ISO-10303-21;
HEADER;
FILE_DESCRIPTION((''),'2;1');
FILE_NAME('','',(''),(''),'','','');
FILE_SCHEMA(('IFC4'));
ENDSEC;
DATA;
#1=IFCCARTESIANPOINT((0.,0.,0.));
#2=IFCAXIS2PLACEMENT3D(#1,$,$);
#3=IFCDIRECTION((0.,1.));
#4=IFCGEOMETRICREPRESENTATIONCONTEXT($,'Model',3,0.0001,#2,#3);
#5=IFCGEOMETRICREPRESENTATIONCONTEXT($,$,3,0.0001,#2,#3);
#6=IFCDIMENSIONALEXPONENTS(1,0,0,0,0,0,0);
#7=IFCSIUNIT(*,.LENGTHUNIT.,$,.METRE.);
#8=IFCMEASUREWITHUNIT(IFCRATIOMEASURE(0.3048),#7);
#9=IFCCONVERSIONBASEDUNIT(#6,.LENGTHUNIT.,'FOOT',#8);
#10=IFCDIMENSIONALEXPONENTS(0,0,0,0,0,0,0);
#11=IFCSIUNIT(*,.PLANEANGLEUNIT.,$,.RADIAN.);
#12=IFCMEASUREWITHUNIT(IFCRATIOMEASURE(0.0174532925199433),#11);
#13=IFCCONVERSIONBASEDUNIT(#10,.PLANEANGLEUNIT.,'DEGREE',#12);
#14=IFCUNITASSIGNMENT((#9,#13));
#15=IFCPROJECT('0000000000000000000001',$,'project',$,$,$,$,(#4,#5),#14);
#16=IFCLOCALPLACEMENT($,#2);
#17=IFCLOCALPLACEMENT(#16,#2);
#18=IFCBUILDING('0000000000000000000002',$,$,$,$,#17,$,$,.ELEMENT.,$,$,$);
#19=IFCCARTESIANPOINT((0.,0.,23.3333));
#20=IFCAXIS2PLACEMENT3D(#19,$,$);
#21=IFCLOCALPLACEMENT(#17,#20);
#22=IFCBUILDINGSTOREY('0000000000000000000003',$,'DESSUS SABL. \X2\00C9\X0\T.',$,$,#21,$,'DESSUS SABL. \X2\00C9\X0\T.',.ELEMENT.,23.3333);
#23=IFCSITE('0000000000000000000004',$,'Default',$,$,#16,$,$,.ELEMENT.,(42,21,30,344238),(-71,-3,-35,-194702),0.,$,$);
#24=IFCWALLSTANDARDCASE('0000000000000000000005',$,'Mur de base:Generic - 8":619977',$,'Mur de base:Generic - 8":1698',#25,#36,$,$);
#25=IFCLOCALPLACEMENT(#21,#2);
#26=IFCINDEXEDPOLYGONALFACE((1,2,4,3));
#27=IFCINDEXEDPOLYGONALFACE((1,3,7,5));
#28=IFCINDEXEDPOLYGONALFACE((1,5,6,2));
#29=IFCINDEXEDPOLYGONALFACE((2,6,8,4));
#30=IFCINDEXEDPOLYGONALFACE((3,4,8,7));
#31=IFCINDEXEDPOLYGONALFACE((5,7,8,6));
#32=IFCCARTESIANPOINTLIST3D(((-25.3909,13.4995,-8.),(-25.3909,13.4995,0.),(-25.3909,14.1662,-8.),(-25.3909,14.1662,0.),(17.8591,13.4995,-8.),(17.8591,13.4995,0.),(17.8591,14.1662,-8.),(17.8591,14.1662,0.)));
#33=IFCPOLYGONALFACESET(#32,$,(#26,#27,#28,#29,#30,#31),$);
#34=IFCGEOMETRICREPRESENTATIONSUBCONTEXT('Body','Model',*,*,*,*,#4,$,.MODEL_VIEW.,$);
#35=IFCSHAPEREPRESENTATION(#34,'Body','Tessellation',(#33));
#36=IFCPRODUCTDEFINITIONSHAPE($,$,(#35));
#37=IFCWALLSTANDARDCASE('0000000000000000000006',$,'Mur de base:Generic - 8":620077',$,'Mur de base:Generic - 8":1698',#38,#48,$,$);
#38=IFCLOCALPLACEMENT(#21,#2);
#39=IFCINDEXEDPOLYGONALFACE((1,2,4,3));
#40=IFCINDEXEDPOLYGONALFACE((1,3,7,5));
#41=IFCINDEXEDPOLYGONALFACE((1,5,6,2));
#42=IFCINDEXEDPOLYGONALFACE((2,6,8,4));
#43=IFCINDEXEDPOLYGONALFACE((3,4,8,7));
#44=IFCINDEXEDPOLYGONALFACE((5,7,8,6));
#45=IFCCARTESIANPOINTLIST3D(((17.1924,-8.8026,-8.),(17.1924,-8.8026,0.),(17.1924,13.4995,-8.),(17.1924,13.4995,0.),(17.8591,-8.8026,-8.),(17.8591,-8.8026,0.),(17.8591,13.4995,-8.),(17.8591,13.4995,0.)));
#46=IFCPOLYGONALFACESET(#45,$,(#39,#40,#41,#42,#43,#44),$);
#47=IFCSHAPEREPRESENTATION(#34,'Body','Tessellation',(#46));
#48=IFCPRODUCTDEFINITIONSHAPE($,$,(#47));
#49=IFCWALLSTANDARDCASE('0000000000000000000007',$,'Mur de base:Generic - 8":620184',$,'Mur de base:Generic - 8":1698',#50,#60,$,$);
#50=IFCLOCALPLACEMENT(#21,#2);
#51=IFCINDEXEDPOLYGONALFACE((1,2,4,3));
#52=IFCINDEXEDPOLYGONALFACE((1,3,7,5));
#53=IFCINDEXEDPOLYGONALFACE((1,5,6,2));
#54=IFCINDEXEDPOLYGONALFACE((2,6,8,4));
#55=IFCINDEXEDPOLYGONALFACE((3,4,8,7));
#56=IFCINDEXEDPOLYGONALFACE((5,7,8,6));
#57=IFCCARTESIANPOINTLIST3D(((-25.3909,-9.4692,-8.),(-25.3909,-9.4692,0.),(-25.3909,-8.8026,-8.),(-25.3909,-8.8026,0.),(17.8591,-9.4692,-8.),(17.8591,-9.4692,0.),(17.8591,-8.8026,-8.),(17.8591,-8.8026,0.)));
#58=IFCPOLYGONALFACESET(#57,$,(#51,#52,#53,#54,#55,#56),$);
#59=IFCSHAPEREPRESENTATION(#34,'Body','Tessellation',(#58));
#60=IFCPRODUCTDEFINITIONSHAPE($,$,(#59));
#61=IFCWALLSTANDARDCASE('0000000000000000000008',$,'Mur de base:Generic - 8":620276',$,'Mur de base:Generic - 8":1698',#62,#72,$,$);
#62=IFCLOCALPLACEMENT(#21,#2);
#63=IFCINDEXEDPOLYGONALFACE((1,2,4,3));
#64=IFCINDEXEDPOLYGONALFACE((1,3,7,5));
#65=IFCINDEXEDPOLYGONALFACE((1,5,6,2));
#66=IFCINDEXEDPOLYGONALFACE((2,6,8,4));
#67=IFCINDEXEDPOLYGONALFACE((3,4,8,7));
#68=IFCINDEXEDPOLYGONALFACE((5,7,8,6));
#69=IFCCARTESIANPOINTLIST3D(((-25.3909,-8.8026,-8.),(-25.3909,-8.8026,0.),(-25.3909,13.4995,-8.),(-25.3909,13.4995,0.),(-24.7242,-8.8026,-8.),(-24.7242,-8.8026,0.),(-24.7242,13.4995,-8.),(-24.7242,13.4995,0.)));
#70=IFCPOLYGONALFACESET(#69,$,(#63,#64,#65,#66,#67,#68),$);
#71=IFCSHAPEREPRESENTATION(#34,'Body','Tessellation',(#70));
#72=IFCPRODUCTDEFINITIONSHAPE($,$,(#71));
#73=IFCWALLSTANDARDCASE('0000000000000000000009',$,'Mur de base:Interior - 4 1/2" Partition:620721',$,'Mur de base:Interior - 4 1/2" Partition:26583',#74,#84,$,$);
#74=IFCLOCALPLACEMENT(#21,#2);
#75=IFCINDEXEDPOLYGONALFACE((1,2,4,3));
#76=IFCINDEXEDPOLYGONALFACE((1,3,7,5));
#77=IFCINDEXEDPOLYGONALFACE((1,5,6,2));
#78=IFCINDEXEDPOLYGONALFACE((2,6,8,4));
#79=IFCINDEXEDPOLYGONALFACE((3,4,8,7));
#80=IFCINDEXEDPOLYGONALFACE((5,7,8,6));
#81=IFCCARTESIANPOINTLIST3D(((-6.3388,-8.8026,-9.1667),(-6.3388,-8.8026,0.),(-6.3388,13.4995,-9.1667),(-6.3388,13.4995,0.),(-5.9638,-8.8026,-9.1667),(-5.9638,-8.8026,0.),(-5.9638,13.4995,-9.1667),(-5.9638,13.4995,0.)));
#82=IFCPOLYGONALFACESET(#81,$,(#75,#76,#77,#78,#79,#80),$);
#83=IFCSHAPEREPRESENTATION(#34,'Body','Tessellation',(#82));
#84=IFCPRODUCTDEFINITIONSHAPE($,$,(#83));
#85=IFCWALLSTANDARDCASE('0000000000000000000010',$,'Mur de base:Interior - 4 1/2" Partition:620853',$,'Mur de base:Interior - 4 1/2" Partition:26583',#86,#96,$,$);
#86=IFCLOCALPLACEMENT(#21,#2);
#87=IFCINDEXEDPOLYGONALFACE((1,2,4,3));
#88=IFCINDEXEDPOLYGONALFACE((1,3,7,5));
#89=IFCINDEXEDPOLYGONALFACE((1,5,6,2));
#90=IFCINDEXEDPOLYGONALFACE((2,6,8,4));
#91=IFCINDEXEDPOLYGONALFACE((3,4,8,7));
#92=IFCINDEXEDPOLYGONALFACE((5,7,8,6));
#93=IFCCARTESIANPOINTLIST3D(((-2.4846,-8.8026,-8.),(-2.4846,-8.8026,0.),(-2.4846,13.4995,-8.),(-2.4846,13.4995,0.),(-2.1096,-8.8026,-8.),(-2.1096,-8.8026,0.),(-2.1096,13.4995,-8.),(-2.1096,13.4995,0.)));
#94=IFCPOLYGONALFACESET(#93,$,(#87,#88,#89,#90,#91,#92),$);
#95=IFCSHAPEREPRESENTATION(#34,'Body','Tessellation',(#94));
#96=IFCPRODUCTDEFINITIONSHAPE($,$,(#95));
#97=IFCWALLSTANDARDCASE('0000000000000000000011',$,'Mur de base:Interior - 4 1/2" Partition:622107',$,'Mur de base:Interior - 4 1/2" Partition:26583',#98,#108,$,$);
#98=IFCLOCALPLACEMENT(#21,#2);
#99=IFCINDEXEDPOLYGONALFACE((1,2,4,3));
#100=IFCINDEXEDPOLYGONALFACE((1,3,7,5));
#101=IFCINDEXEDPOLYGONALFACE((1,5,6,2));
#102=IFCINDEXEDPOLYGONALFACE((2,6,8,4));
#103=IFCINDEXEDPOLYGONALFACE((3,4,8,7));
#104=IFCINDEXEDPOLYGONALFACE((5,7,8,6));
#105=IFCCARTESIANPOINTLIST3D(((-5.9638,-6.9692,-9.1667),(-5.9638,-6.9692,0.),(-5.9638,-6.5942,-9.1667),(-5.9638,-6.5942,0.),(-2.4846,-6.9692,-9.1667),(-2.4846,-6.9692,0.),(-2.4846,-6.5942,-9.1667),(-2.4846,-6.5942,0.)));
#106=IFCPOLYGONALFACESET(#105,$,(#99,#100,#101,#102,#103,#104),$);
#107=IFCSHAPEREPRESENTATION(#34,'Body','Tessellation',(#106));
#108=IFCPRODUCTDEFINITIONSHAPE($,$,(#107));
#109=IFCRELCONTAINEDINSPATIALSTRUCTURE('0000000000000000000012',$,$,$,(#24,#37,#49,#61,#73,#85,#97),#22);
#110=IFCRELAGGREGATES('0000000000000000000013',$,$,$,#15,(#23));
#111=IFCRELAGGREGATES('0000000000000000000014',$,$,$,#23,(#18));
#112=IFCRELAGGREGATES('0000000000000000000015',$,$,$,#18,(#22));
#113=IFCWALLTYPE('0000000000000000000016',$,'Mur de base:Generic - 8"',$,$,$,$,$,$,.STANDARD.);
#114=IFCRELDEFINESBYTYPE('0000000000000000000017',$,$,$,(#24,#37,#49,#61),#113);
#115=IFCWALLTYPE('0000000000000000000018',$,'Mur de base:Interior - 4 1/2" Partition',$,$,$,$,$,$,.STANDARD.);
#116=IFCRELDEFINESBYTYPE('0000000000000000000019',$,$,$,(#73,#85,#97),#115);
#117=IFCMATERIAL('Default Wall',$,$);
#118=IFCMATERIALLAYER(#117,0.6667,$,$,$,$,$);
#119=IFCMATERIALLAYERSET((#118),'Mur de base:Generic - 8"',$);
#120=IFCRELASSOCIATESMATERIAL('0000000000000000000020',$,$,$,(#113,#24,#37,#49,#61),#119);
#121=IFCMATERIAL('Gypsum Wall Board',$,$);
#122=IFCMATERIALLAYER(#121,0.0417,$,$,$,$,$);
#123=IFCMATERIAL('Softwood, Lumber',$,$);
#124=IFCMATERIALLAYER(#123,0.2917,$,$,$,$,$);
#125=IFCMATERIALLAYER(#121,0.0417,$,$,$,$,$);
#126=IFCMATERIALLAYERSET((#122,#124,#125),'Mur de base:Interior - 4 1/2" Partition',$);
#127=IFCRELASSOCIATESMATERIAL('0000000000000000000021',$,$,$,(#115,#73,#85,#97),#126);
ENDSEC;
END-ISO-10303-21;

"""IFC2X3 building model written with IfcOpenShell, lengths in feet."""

from ifc_helpers import new_model, entity, si_unit, converted_unit, direction, frame, frame_2d, origin, place, context, subcontext, project, spatial, rectangle, extrude, material, layer, layer_set, layer_usage, type_object, element, save


model = new_model("IFC2X3")

# Units and contexts
model_context = context("Model", 3, precision=0.0001, world=origin(), true_north=direction((0.0, 1.0)))
context_of_model = context(None, 3, precision=0.0001, world=origin(), true_north=direction((0.0, 1.0)))
body_context = subcontext(model_context, "Body", "Model", "MODEL_VIEW")
ifc_project = project(units=[converted_unit("LENGTHUNIT", "FOOT", entity("IfcRatioMeasure", 0.3048), si_unit("LENGTHUNIT", "METRE"), dimensions=[1, 0, 0, 0, 0, 0, 0]), converted_unit("PLANEANGLEUNIT", "DEGREE", entity("IfcRatioMeasure", 0.0174532925199433), si_unit("PLANEANGLEUNIT", "RADIAN"), dimensions=[0, 0, 0, 0, 0, 0, 0])], contexts=[model_context, context_of_model])

# Site, building, storey
site_placement = place(None, origin())
site = spatial("IfcSite", under=ifc_project, at=site_placement, Name="Default", CompositionType="ELEMENT", RefLatitude=(42, 21, 30, 344238), RefLongitude=(-71, -3, -35, -194702), RefElevation=0.0)
building_placement = place(site_placement, origin())
building = spatial("IfcBuilding", under=site, at=building_placement, CompositionType="ELEMENT")
storey_placement = place(building_placement, frame((0.0, 0.0, 23.3333)))
storey = spatial("IfcBuildingStorey", under=building, at=storey_placement, Name="DESSUS SABL. ÉT.", LongName="DESSUS SABL. ÉT.", CompositionType="ELEMENT", Elevation=23.3333)

# Walls
ifc_material_1 = material(Name="Default Wall")
ifc_layer_1 = layer(ifc_material_1, 0.6667)
ifc_layer_set_1 = layer_set([ifc_layer_1], Name="Mur de base:Generic - 8\"")
ifc_layer_usage_1 = layer_usage(ifc_layer_set_1, "AXIS2", "NEGATIVE", 0.3333)
wall_type_1 = type_object("IfcWallType", Name="Mur de base:Generic - 8\"", PredefinedType="STANDARD", material=ifc_layer_set_1)
wall_1_placement = place(storey_placement, frame((-25.3909, 13.8328, -8.0)))
element("IfcWallStandardCase", 1, at=wall_1_placement, inside=storey, type_object=wall_type_1, material=ifc_layer_usage_1, Name="Mur de base:Generic - 8\":619977", ObjectType="Mur de base:Generic - 8\":1698", context=body_context, shape_type="SweptSolid", body=[
    extrude(rectangle(XDim=43.25, YDim=0.6667, at=frame_2d((21.625, 0.0), x_axis=(-1.0, 0.0))), origin(), (0.0, 0.0, 1.0), 8.0),
])
ifc_layer_usage_2 = layer_usage(ifc_layer_set_1, "AXIS2", "NEGATIVE", 0.3333)
wall_2_placement = place(storey_placement, frame((17.5258, 13.4995, -8.0), z_axis=(0.0, 0.0, 1.0), x_axis=(0.0, -1.0, 0.0)))
element("IfcWallStandardCase", 2, at=wall_2_placement, inside=storey, type_object=wall_type_1, material=ifc_layer_usage_2, Name="Mur de base:Generic - 8\":620077", ObjectType="Mur de base:Generic - 8\":1698", context=body_context, shape_type="SweptSolid", body=[
    extrude(rectangle(XDim=22.3021, YDim=0.6667, at=frame_2d((11.151, 0.0), x_axis=(-1.0, 0.0))), origin(), (0.0, 0.0, 1.0), 8.0),
])
ifc_layer_usage_3 = layer_usage(ifc_layer_set_1, "AXIS2", "NEGATIVE", 0.3333)
wall_3_placement = place(storey_placement, frame((17.8591, -9.1359, -8.0), z_axis=(0.0, 0.0, 1.0), x_axis=(-1.0, 0.0, 0.0)))
element("IfcWallStandardCase", 3, at=wall_3_placement, inside=storey, type_object=wall_type_1, material=ifc_layer_usage_3, Name="Mur de base:Generic - 8\":620184", ObjectType="Mur de base:Generic - 8\":1698", context=body_context, shape_type="SweptSolid", body=[
    extrude(rectangle(XDim=43.25, YDim=0.6667, at=frame_2d((21.625, 0.0), x_axis=(-1.0, 0.0))), origin(), (0.0, 0.0, 1.0), 8.0),
])
ifc_layer_usage_4 = layer_usage(ifc_layer_set_1, "AXIS2", "NEGATIVE", 0.3333)
wall_4_placement = place(storey_placement, frame((-25.0576, -8.8026, -8.0), z_axis=(0.0, 0.0, 1.0), x_axis=(0.0, 1.0, 0.0)))
element("IfcWallStandardCase", 4, at=wall_4_placement, inside=storey, type_object=wall_type_1, material=ifc_layer_usage_4, Name="Mur de base:Generic - 8\":620276", ObjectType="Mur de base:Generic - 8\":1698", context=body_context, shape_type="SweptSolid", body=[
    extrude(rectangle(XDim=22.3021, YDim=0.6667, at=frame_2d((11.151, 0.0), x_axis=(-1.0, 0.0))), origin(), (0.0, 0.0, 1.0), 8.0),
])
ifc_material_2 = material(Name="Gypsum Wall Board")
ifc_layer_2 = layer(ifc_material_2, 0.0417)
ifc_material_3 = material(Name="Softwood, Lumber")
ifc_layer_3 = layer(ifc_material_3, 0.2917)
ifc_layer_4 = layer(ifc_material_2, 0.0417)
ifc_layer_set_2 = layer_set([ifc_layer_2, ifc_layer_3, ifc_layer_4], Name="Mur de base:Interior - 4 1/2\" Partition")
ifc_layer_usage_5 = layer_usage(ifc_layer_set_2, "AXIS2", "NEGATIVE", 0.1875)
wall_type_2 = type_object("IfcWallType", Name="Mur de base:Interior - 4 1/2\" Partition", PredefinedType="STANDARD", material=ifc_layer_set_2)
wall_5_placement = place(storey_placement, frame((-6.1513, 13.4995, -9.1667), z_axis=(0.0, 0.0, 1.0), x_axis=(0.0, -1.0, 0.0)))
element("IfcWallStandardCase", 5, at=wall_5_placement, inside=storey, type_object=wall_type_2, material=ifc_layer_usage_5, Name="Mur de base:Interior - 4 1/2\" Partition:620721", ObjectType="Mur de base:Interior - 4 1/2\" Partition:26583", context=body_context, shape_type="SweptSolid", body=[
    extrude(rectangle(XDim=22.3021, YDim=0.375, at=frame_2d((11.151, 0.0), x_axis=(-1.0, 0.0))), origin(), (0.0, 0.0, 1.0), 9.1667),
])
ifc_layer_usage_6 = layer_usage(ifc_layer_set_2, "AXIS2", "NEGATIVE", 0.1875)
wall_6_placement = place(storey_placement, frame((-2.2971, 13.4995, -8.0), z_axis=(0.0, 0.0, 1.0), x_axis=(0.0, -1.0, 0.0)))
element("IfcWallStandardCase", 6, at=wall_6_placement, inside=storey, type_object=wall_type_2, material=ifc_layer_usage_6, Name="Mur de base:Interior - 4 1/2\" Partition:620853", ObjectType="Mur de base:Interior - 4 1/2\" Partition:26583", context=body_context, shape_type="SweptSolid", body=[
    extrude(rectangle(XDim=22.3021, YDim=0.375, at=frame_2d((11.151, 0.0), x_axis=(-1.0, 0.0))), origin(), (0.0, 0.0, 1.0), 8.0),
])
ifc_layer_usage_7 = layer_usage(ifc_layer_set_2, "AXIS2", "NEGATIVE", 0.1875)
wall_7_placement = place(storey_placement, frame((-5.9638, -6.7817, -9.1667)))
element("IfcWallStandardCase", 7, at=wall_7_placement, inside=storey, type_object=wall_type_2, material=ifc_layer_usage_7, Name="Mur de base:Interior - 4 1/2\" Partition:622107", ObjectType="Mur de base:Interior - 4 1/2\" Partition:26583", context=body_context, shape_type="SweptSolid", body=[
    extrude(rectangle(XDim=3.4792, YDim=0.375, at=frame_2d((1.7396, 0.0), x_axis=(-1.0, 0.0))), origin(), (0.0, 0.0, 1.0), 9.1667),
])

save(model, "model.ifc")
